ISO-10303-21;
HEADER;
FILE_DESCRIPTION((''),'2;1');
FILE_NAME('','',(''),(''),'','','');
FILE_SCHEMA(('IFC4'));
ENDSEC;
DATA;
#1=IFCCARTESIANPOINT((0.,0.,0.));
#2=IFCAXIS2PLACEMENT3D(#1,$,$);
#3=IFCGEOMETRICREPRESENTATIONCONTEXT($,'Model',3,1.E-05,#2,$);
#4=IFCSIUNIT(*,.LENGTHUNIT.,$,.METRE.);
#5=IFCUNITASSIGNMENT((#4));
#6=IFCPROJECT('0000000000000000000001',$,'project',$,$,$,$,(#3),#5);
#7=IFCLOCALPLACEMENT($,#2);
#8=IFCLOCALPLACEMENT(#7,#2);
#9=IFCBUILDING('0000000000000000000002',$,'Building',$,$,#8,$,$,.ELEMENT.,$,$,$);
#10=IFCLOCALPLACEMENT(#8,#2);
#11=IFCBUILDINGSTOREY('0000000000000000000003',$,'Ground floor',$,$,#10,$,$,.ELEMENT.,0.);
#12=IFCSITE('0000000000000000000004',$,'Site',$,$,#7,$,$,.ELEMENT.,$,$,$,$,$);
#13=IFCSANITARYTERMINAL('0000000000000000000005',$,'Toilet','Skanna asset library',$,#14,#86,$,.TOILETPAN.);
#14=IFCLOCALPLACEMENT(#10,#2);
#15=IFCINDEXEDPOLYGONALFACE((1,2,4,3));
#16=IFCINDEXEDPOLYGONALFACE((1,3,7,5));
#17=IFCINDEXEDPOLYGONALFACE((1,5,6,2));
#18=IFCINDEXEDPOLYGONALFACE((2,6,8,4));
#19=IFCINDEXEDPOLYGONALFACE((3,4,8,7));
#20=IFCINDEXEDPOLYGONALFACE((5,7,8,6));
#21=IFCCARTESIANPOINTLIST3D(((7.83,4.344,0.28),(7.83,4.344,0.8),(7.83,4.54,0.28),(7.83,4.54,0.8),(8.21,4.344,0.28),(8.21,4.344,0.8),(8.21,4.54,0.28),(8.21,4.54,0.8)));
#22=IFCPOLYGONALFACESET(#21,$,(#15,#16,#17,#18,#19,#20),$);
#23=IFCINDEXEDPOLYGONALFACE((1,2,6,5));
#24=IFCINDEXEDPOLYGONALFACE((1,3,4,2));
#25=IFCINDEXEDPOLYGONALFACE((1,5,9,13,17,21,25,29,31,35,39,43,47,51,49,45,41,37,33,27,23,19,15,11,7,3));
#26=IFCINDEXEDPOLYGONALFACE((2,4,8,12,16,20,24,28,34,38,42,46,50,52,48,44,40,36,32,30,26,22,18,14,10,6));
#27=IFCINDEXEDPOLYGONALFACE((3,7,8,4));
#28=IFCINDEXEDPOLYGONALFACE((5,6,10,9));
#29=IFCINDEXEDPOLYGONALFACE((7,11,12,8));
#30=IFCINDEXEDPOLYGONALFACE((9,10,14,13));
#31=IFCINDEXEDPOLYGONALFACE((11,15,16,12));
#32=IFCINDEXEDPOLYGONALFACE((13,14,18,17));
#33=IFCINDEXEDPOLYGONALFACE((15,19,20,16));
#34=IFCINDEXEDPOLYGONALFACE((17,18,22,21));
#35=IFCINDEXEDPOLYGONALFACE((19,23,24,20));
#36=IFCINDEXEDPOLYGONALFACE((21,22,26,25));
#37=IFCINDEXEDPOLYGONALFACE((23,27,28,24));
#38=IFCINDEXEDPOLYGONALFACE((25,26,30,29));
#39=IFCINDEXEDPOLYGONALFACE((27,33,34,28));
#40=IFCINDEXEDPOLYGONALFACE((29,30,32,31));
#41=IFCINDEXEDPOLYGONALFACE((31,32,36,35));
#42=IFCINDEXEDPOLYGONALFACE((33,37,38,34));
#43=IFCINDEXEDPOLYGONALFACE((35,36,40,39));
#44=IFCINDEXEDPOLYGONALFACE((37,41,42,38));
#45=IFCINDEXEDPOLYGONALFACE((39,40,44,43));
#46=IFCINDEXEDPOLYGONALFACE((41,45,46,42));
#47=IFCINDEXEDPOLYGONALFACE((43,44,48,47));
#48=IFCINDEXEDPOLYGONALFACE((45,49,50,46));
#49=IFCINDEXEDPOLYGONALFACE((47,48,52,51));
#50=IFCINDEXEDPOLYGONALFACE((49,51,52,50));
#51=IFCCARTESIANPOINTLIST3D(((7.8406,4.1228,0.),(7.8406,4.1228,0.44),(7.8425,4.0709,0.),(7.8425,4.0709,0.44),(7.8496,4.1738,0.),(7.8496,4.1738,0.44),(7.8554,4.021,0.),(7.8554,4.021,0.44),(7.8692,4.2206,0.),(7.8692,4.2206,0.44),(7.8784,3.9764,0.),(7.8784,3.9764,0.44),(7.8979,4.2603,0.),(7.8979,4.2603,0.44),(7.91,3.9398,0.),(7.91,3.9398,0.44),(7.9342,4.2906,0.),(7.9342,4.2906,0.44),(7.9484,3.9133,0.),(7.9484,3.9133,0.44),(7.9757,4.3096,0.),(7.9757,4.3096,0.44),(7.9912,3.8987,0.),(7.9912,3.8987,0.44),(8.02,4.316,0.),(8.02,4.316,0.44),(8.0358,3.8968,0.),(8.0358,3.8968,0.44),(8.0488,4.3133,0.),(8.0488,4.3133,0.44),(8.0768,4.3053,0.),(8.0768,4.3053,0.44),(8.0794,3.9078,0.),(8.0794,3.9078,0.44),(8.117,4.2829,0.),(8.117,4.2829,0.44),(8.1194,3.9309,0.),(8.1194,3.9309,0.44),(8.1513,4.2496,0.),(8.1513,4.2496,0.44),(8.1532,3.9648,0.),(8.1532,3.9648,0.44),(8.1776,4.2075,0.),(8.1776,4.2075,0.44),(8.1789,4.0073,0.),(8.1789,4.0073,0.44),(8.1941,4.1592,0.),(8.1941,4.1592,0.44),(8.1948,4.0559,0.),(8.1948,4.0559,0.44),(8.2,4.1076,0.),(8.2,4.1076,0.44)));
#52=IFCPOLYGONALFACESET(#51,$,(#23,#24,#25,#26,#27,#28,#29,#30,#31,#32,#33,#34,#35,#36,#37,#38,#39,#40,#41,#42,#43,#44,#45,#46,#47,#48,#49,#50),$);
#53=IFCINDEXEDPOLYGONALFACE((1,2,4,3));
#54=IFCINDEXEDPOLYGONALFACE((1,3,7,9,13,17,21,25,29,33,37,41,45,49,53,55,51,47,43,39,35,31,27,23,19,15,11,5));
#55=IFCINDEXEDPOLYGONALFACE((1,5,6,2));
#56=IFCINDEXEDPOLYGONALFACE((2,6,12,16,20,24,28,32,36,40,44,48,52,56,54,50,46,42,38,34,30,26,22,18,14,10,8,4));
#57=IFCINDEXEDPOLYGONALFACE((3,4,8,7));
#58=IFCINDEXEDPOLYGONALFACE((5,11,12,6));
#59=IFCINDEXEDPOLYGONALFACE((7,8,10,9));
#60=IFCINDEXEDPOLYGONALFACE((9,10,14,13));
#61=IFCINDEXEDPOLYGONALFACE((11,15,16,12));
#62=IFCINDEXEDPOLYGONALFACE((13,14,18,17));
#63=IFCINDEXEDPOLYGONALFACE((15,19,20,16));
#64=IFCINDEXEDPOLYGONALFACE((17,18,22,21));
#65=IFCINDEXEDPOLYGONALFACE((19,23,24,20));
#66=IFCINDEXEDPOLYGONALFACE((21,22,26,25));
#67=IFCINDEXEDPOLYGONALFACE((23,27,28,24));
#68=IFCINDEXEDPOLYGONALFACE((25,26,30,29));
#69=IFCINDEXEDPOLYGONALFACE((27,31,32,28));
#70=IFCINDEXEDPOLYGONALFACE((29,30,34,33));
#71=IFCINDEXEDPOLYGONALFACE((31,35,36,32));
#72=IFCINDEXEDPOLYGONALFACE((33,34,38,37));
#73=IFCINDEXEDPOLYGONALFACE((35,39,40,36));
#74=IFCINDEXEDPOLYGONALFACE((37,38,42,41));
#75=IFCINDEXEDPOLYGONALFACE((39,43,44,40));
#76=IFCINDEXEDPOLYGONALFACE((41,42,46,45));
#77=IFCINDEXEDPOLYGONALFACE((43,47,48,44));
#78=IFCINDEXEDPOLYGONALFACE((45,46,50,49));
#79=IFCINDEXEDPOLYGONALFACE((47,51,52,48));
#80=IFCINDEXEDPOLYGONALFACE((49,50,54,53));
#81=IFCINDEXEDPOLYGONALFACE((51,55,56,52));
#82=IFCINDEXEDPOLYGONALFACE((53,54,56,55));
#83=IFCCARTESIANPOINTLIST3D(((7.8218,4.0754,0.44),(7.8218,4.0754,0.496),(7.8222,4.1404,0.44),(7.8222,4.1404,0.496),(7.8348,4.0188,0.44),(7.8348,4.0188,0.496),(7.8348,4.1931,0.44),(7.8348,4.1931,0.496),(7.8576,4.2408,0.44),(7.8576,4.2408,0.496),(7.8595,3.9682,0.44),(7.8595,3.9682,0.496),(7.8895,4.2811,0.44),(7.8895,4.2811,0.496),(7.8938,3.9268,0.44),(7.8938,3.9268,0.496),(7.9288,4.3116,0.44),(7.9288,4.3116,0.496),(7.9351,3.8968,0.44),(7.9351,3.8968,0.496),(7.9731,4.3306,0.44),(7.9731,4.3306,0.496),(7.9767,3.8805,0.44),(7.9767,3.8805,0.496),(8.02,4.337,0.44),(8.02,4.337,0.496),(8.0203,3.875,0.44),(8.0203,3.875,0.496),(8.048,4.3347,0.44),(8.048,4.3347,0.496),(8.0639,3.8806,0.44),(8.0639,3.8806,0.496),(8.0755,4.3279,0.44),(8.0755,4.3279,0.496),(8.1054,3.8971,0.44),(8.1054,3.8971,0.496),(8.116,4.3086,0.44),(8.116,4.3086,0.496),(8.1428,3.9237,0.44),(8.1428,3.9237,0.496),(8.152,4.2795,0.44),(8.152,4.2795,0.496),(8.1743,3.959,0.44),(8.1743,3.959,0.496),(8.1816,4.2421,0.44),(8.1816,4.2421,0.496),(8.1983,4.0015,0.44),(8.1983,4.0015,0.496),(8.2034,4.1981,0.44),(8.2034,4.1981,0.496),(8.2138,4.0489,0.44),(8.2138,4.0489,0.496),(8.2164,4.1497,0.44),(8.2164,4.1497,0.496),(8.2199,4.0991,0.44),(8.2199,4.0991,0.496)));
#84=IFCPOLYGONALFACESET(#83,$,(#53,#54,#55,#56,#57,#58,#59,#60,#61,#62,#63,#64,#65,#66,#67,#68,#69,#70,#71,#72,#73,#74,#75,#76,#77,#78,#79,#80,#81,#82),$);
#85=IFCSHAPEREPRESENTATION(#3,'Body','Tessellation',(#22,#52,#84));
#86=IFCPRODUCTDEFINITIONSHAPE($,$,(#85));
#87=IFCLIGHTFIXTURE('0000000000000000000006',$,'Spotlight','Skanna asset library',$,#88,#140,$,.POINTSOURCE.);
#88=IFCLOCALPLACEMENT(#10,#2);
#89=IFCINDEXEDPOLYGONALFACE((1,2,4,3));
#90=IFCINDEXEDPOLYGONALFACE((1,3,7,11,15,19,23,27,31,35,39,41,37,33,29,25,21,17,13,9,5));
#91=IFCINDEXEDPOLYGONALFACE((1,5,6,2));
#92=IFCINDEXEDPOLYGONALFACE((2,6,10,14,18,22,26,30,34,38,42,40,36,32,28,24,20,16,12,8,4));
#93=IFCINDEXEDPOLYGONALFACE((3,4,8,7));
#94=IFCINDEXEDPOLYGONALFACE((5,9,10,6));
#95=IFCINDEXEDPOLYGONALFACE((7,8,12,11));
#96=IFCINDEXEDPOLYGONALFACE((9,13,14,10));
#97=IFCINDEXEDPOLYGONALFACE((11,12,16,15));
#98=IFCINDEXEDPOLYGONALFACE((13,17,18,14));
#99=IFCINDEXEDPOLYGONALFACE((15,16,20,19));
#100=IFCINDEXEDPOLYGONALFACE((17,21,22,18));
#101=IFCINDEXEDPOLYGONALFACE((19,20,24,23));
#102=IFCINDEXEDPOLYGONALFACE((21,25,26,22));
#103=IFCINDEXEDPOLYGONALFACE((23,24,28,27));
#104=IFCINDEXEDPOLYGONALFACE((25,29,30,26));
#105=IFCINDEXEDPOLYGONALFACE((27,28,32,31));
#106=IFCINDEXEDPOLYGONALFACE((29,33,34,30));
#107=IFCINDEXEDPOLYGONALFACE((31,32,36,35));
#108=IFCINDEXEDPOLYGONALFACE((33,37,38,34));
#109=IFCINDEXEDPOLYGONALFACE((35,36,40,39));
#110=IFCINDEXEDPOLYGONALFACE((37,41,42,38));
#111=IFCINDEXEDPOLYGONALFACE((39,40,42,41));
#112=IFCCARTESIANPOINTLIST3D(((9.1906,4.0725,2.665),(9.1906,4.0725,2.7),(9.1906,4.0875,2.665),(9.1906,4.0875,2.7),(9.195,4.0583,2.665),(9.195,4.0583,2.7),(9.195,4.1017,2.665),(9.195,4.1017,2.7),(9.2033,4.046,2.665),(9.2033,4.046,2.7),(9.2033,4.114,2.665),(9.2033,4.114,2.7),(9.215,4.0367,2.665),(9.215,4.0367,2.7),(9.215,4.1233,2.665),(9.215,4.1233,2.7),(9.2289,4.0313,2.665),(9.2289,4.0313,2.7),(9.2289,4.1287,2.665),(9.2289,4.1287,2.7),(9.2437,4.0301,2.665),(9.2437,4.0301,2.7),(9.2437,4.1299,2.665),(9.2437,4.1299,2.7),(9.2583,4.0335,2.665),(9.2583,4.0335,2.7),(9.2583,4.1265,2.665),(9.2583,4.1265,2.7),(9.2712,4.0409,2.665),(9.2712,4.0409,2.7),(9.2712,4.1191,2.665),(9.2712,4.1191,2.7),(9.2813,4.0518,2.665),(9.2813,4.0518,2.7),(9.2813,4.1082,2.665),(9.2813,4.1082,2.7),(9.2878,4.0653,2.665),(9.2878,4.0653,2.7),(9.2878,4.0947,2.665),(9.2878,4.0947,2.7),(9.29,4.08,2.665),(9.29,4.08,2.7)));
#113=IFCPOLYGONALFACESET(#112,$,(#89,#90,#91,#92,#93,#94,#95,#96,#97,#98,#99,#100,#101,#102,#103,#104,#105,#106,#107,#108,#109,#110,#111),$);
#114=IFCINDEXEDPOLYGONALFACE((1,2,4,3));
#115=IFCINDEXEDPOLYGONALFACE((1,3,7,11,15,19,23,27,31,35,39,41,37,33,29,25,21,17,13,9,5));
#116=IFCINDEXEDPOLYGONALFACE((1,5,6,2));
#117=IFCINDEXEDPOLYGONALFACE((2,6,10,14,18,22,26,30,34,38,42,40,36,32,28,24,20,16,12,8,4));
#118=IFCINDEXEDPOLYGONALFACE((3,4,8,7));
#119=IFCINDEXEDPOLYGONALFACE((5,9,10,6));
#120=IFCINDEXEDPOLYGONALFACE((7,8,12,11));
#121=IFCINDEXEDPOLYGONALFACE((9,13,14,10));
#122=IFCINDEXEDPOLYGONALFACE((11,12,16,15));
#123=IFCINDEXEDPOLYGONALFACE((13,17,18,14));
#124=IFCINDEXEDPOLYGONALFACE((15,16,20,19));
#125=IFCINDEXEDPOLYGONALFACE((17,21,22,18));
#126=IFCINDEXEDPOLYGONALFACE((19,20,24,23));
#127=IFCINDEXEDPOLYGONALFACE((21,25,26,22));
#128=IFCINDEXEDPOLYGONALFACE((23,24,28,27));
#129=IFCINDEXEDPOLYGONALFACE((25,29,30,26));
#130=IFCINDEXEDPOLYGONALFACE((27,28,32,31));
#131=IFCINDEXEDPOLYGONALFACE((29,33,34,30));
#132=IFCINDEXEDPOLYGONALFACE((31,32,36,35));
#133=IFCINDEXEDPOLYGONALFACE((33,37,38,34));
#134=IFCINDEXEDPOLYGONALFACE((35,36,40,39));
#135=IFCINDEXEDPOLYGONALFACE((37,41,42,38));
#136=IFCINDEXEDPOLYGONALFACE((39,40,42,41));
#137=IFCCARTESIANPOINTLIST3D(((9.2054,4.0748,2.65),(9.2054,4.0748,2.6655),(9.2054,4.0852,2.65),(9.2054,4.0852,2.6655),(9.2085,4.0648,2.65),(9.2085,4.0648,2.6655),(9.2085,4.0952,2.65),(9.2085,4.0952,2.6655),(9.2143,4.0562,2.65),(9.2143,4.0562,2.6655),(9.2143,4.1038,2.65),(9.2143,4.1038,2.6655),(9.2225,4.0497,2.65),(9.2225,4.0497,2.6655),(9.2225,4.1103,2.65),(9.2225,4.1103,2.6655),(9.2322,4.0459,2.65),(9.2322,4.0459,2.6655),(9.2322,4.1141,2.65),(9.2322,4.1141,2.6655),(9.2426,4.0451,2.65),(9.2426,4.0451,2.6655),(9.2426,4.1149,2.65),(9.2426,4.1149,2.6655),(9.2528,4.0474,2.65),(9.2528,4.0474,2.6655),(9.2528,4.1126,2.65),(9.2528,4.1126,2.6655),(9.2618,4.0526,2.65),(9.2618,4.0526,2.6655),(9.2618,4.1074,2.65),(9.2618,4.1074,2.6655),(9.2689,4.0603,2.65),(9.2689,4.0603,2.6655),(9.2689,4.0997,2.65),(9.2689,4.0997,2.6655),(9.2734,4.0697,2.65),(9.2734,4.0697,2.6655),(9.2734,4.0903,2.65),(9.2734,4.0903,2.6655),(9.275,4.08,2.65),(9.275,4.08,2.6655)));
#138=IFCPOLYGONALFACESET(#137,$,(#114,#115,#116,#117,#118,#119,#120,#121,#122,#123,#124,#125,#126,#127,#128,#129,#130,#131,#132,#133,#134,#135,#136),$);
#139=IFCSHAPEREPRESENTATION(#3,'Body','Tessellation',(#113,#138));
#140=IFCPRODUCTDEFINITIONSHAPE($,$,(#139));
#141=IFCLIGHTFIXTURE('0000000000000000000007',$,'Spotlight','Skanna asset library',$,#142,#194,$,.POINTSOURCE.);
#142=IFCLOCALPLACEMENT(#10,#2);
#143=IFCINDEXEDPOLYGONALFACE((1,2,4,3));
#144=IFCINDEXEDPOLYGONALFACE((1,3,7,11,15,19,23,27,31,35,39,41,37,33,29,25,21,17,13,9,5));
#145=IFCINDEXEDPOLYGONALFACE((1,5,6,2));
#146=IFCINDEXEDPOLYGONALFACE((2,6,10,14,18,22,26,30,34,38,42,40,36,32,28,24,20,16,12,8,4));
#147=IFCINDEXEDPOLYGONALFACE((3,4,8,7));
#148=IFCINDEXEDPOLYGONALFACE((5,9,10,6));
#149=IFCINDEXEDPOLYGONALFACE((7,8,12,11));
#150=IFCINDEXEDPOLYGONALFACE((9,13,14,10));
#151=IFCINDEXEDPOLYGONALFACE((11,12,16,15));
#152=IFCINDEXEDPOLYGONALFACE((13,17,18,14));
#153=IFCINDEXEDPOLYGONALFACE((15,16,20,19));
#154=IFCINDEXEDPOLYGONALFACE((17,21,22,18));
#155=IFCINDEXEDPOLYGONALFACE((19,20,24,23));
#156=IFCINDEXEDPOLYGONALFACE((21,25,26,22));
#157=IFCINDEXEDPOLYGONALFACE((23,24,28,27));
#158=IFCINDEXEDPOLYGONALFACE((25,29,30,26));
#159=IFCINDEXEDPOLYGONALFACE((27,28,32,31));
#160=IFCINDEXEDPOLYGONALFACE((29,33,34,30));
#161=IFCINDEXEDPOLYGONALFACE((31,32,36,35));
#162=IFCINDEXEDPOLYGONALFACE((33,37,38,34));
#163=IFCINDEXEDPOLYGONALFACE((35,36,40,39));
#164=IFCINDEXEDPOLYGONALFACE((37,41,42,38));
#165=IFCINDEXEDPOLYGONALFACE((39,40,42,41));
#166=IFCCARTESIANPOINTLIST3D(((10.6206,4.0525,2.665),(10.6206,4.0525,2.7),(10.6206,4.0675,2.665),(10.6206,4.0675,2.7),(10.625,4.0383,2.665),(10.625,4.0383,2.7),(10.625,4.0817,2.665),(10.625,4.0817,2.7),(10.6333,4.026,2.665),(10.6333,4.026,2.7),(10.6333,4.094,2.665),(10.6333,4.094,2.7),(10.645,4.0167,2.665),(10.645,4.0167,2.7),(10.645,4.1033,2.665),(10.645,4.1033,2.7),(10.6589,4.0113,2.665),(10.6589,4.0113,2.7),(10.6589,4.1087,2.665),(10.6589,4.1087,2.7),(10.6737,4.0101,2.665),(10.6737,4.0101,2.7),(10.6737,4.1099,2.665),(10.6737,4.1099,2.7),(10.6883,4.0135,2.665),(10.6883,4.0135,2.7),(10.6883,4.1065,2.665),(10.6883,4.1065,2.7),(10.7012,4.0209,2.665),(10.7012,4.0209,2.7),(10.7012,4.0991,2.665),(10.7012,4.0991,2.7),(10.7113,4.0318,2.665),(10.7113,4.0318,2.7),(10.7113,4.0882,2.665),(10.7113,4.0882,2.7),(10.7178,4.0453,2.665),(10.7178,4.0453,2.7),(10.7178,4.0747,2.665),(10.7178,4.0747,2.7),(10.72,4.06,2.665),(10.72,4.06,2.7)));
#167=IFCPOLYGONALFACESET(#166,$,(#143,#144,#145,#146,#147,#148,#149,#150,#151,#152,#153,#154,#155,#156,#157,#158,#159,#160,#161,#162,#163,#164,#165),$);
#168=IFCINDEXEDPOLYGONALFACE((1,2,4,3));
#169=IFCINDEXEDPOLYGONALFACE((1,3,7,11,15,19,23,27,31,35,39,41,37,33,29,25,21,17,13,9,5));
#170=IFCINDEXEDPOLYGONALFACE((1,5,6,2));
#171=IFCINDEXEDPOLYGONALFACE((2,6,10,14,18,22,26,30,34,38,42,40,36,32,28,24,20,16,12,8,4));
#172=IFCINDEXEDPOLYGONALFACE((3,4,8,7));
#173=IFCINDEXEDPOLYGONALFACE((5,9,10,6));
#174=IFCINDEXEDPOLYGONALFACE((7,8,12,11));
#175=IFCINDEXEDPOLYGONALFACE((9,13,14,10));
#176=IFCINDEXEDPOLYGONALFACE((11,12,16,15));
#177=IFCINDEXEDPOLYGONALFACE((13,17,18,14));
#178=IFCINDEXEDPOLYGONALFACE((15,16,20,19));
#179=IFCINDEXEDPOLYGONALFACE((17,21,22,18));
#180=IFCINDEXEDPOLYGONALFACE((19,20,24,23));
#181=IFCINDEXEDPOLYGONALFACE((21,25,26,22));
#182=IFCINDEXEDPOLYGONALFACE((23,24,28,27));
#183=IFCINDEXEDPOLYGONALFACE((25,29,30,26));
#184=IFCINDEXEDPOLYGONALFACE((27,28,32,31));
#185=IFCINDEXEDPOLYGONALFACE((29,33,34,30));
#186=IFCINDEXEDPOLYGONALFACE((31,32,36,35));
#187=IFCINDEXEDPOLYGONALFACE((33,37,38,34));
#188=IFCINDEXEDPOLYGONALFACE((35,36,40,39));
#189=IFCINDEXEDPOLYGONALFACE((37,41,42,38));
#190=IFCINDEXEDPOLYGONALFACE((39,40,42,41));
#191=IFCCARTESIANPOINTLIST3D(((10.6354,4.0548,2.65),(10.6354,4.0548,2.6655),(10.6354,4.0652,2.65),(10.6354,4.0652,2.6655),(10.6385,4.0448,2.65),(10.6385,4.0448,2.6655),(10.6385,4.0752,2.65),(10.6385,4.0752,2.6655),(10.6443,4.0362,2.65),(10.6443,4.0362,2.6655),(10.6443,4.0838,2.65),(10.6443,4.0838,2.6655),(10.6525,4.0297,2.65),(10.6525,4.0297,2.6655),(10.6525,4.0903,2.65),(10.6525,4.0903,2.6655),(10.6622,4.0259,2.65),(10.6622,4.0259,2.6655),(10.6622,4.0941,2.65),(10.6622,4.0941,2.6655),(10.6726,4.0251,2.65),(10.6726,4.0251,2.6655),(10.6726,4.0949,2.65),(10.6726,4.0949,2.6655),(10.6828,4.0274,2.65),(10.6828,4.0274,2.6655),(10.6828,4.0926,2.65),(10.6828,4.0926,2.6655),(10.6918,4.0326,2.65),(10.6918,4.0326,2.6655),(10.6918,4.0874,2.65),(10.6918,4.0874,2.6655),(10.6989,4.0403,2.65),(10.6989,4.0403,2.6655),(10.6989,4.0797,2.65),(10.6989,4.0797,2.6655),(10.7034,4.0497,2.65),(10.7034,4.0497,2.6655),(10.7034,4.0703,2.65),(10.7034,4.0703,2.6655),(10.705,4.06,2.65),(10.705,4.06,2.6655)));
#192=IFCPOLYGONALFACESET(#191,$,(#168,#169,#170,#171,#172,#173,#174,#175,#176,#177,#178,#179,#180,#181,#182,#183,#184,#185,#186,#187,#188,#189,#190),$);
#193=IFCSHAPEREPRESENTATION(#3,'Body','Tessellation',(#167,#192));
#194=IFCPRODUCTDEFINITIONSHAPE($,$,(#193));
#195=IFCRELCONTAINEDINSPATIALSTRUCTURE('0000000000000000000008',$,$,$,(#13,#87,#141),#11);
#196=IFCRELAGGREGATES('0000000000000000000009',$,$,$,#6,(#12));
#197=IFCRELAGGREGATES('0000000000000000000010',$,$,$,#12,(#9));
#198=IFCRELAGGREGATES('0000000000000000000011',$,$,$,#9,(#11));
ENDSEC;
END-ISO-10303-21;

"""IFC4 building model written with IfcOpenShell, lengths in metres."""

from ifc_helpers import new_model, si_unit, frame, frame_2d, origin, origin_2d, place, context, project, spatial, rectangle, circle, ellipse, extrude, element, save


model = new_model("IFC4")

# Units and contexts
model_context = context("Model", 3, precision=1e-05, world=origin())
ifc_project = project(units=[si_unit("LENGTHUNIT", "METRE")], contexts=[model_context])

# Site, building, storey
site_placement = place(None, origin())
site = spatial("IfcSite", under=ifc_project, at=site_placement, Name="Site", CompositionType="ELEMENT")
building_placement = place(site_placement, origin())
building = spatial("IfcBuilding", under=site, at=building_placement, Name="Building", CompositionType="ELEMENT")
storey_placement = place(building_placement, origin())
storey = spatial("IfcBuildingStorey", under=building, at=storey_placement, Name="Ground floor", CompositionType="ELEMENT", Elevation=0.0)

# Sanitary terminal
sanitary_terminal_1_placement = place(storey_placement, frame((8.02, 4.19, 0.0), z_axis=(0.0, 0.0, 1.0), x_axis=(1.0, 0.0, 0.0)))
element("IfcSanitaryTerminal", 1, at=sanitary_terminal_1_placement, inside=storey, Name="Toilet", Description="Skanna asset library", PredefinedType="TOILETPAN", context=model_context, shape_type="SweptSolid", body=[
    extrude(rectangle(XDim=0.38, YDim=0.196, at=frame_2d((0.0, 0.252))), frame((0.0, 0.0, 0.28)), (0.0, 0.0, 1.0), 0.52),
    extrude(ellipse(SemiAxis1=0.18, SemiAxis2=0.21, at=frame_2d((0.0, -0.084))), origin(), (0.0, 0.0, 1.0), 0.44),
    extrude(ellipse(SemiAxis1=0.2, SemiAxis2=0.231, at=frame_2d((0.0, -0.084))), frame((0.0, 0.0, 0.44)), (0.0, 0.0, 1.0), 0.056),
])

# Light fixtures
for number, where, z_axis, x_axis, name in (
    (2, (9.24, 4.08, 2.65), (0.0, 0.0, 1.0), (1.0, 0.0, 0.0), "Spotlight"),
    (3, (10.67, 4.06, 2.65), (0.0, 0.0, 1.0), (1.0, 0.0, 0.0), "Spotlight"),
):
    element("IfcLightFixture", number, at=place(storey_placement, frame(where, z_axis=z_axis, x_axis=x_axis)), inside=storey, Name=name, Description="Skanna asset library", PredefinedType="POINTSOURCE", context=model_context, shape_type="SweptSolid", body=[
        extrude(circle(Radius=0.05, at=origin_2d()), frame((0.0, 0.0, 0.015)), (0.0, 0.0, 1.0), 0.035),
        extrude(circle(Radius=0.035, at=origin_2d()), origin(), (0.0, 0.0, 1.0), 0.0155),
    ])

save(model, "model.ifc")
